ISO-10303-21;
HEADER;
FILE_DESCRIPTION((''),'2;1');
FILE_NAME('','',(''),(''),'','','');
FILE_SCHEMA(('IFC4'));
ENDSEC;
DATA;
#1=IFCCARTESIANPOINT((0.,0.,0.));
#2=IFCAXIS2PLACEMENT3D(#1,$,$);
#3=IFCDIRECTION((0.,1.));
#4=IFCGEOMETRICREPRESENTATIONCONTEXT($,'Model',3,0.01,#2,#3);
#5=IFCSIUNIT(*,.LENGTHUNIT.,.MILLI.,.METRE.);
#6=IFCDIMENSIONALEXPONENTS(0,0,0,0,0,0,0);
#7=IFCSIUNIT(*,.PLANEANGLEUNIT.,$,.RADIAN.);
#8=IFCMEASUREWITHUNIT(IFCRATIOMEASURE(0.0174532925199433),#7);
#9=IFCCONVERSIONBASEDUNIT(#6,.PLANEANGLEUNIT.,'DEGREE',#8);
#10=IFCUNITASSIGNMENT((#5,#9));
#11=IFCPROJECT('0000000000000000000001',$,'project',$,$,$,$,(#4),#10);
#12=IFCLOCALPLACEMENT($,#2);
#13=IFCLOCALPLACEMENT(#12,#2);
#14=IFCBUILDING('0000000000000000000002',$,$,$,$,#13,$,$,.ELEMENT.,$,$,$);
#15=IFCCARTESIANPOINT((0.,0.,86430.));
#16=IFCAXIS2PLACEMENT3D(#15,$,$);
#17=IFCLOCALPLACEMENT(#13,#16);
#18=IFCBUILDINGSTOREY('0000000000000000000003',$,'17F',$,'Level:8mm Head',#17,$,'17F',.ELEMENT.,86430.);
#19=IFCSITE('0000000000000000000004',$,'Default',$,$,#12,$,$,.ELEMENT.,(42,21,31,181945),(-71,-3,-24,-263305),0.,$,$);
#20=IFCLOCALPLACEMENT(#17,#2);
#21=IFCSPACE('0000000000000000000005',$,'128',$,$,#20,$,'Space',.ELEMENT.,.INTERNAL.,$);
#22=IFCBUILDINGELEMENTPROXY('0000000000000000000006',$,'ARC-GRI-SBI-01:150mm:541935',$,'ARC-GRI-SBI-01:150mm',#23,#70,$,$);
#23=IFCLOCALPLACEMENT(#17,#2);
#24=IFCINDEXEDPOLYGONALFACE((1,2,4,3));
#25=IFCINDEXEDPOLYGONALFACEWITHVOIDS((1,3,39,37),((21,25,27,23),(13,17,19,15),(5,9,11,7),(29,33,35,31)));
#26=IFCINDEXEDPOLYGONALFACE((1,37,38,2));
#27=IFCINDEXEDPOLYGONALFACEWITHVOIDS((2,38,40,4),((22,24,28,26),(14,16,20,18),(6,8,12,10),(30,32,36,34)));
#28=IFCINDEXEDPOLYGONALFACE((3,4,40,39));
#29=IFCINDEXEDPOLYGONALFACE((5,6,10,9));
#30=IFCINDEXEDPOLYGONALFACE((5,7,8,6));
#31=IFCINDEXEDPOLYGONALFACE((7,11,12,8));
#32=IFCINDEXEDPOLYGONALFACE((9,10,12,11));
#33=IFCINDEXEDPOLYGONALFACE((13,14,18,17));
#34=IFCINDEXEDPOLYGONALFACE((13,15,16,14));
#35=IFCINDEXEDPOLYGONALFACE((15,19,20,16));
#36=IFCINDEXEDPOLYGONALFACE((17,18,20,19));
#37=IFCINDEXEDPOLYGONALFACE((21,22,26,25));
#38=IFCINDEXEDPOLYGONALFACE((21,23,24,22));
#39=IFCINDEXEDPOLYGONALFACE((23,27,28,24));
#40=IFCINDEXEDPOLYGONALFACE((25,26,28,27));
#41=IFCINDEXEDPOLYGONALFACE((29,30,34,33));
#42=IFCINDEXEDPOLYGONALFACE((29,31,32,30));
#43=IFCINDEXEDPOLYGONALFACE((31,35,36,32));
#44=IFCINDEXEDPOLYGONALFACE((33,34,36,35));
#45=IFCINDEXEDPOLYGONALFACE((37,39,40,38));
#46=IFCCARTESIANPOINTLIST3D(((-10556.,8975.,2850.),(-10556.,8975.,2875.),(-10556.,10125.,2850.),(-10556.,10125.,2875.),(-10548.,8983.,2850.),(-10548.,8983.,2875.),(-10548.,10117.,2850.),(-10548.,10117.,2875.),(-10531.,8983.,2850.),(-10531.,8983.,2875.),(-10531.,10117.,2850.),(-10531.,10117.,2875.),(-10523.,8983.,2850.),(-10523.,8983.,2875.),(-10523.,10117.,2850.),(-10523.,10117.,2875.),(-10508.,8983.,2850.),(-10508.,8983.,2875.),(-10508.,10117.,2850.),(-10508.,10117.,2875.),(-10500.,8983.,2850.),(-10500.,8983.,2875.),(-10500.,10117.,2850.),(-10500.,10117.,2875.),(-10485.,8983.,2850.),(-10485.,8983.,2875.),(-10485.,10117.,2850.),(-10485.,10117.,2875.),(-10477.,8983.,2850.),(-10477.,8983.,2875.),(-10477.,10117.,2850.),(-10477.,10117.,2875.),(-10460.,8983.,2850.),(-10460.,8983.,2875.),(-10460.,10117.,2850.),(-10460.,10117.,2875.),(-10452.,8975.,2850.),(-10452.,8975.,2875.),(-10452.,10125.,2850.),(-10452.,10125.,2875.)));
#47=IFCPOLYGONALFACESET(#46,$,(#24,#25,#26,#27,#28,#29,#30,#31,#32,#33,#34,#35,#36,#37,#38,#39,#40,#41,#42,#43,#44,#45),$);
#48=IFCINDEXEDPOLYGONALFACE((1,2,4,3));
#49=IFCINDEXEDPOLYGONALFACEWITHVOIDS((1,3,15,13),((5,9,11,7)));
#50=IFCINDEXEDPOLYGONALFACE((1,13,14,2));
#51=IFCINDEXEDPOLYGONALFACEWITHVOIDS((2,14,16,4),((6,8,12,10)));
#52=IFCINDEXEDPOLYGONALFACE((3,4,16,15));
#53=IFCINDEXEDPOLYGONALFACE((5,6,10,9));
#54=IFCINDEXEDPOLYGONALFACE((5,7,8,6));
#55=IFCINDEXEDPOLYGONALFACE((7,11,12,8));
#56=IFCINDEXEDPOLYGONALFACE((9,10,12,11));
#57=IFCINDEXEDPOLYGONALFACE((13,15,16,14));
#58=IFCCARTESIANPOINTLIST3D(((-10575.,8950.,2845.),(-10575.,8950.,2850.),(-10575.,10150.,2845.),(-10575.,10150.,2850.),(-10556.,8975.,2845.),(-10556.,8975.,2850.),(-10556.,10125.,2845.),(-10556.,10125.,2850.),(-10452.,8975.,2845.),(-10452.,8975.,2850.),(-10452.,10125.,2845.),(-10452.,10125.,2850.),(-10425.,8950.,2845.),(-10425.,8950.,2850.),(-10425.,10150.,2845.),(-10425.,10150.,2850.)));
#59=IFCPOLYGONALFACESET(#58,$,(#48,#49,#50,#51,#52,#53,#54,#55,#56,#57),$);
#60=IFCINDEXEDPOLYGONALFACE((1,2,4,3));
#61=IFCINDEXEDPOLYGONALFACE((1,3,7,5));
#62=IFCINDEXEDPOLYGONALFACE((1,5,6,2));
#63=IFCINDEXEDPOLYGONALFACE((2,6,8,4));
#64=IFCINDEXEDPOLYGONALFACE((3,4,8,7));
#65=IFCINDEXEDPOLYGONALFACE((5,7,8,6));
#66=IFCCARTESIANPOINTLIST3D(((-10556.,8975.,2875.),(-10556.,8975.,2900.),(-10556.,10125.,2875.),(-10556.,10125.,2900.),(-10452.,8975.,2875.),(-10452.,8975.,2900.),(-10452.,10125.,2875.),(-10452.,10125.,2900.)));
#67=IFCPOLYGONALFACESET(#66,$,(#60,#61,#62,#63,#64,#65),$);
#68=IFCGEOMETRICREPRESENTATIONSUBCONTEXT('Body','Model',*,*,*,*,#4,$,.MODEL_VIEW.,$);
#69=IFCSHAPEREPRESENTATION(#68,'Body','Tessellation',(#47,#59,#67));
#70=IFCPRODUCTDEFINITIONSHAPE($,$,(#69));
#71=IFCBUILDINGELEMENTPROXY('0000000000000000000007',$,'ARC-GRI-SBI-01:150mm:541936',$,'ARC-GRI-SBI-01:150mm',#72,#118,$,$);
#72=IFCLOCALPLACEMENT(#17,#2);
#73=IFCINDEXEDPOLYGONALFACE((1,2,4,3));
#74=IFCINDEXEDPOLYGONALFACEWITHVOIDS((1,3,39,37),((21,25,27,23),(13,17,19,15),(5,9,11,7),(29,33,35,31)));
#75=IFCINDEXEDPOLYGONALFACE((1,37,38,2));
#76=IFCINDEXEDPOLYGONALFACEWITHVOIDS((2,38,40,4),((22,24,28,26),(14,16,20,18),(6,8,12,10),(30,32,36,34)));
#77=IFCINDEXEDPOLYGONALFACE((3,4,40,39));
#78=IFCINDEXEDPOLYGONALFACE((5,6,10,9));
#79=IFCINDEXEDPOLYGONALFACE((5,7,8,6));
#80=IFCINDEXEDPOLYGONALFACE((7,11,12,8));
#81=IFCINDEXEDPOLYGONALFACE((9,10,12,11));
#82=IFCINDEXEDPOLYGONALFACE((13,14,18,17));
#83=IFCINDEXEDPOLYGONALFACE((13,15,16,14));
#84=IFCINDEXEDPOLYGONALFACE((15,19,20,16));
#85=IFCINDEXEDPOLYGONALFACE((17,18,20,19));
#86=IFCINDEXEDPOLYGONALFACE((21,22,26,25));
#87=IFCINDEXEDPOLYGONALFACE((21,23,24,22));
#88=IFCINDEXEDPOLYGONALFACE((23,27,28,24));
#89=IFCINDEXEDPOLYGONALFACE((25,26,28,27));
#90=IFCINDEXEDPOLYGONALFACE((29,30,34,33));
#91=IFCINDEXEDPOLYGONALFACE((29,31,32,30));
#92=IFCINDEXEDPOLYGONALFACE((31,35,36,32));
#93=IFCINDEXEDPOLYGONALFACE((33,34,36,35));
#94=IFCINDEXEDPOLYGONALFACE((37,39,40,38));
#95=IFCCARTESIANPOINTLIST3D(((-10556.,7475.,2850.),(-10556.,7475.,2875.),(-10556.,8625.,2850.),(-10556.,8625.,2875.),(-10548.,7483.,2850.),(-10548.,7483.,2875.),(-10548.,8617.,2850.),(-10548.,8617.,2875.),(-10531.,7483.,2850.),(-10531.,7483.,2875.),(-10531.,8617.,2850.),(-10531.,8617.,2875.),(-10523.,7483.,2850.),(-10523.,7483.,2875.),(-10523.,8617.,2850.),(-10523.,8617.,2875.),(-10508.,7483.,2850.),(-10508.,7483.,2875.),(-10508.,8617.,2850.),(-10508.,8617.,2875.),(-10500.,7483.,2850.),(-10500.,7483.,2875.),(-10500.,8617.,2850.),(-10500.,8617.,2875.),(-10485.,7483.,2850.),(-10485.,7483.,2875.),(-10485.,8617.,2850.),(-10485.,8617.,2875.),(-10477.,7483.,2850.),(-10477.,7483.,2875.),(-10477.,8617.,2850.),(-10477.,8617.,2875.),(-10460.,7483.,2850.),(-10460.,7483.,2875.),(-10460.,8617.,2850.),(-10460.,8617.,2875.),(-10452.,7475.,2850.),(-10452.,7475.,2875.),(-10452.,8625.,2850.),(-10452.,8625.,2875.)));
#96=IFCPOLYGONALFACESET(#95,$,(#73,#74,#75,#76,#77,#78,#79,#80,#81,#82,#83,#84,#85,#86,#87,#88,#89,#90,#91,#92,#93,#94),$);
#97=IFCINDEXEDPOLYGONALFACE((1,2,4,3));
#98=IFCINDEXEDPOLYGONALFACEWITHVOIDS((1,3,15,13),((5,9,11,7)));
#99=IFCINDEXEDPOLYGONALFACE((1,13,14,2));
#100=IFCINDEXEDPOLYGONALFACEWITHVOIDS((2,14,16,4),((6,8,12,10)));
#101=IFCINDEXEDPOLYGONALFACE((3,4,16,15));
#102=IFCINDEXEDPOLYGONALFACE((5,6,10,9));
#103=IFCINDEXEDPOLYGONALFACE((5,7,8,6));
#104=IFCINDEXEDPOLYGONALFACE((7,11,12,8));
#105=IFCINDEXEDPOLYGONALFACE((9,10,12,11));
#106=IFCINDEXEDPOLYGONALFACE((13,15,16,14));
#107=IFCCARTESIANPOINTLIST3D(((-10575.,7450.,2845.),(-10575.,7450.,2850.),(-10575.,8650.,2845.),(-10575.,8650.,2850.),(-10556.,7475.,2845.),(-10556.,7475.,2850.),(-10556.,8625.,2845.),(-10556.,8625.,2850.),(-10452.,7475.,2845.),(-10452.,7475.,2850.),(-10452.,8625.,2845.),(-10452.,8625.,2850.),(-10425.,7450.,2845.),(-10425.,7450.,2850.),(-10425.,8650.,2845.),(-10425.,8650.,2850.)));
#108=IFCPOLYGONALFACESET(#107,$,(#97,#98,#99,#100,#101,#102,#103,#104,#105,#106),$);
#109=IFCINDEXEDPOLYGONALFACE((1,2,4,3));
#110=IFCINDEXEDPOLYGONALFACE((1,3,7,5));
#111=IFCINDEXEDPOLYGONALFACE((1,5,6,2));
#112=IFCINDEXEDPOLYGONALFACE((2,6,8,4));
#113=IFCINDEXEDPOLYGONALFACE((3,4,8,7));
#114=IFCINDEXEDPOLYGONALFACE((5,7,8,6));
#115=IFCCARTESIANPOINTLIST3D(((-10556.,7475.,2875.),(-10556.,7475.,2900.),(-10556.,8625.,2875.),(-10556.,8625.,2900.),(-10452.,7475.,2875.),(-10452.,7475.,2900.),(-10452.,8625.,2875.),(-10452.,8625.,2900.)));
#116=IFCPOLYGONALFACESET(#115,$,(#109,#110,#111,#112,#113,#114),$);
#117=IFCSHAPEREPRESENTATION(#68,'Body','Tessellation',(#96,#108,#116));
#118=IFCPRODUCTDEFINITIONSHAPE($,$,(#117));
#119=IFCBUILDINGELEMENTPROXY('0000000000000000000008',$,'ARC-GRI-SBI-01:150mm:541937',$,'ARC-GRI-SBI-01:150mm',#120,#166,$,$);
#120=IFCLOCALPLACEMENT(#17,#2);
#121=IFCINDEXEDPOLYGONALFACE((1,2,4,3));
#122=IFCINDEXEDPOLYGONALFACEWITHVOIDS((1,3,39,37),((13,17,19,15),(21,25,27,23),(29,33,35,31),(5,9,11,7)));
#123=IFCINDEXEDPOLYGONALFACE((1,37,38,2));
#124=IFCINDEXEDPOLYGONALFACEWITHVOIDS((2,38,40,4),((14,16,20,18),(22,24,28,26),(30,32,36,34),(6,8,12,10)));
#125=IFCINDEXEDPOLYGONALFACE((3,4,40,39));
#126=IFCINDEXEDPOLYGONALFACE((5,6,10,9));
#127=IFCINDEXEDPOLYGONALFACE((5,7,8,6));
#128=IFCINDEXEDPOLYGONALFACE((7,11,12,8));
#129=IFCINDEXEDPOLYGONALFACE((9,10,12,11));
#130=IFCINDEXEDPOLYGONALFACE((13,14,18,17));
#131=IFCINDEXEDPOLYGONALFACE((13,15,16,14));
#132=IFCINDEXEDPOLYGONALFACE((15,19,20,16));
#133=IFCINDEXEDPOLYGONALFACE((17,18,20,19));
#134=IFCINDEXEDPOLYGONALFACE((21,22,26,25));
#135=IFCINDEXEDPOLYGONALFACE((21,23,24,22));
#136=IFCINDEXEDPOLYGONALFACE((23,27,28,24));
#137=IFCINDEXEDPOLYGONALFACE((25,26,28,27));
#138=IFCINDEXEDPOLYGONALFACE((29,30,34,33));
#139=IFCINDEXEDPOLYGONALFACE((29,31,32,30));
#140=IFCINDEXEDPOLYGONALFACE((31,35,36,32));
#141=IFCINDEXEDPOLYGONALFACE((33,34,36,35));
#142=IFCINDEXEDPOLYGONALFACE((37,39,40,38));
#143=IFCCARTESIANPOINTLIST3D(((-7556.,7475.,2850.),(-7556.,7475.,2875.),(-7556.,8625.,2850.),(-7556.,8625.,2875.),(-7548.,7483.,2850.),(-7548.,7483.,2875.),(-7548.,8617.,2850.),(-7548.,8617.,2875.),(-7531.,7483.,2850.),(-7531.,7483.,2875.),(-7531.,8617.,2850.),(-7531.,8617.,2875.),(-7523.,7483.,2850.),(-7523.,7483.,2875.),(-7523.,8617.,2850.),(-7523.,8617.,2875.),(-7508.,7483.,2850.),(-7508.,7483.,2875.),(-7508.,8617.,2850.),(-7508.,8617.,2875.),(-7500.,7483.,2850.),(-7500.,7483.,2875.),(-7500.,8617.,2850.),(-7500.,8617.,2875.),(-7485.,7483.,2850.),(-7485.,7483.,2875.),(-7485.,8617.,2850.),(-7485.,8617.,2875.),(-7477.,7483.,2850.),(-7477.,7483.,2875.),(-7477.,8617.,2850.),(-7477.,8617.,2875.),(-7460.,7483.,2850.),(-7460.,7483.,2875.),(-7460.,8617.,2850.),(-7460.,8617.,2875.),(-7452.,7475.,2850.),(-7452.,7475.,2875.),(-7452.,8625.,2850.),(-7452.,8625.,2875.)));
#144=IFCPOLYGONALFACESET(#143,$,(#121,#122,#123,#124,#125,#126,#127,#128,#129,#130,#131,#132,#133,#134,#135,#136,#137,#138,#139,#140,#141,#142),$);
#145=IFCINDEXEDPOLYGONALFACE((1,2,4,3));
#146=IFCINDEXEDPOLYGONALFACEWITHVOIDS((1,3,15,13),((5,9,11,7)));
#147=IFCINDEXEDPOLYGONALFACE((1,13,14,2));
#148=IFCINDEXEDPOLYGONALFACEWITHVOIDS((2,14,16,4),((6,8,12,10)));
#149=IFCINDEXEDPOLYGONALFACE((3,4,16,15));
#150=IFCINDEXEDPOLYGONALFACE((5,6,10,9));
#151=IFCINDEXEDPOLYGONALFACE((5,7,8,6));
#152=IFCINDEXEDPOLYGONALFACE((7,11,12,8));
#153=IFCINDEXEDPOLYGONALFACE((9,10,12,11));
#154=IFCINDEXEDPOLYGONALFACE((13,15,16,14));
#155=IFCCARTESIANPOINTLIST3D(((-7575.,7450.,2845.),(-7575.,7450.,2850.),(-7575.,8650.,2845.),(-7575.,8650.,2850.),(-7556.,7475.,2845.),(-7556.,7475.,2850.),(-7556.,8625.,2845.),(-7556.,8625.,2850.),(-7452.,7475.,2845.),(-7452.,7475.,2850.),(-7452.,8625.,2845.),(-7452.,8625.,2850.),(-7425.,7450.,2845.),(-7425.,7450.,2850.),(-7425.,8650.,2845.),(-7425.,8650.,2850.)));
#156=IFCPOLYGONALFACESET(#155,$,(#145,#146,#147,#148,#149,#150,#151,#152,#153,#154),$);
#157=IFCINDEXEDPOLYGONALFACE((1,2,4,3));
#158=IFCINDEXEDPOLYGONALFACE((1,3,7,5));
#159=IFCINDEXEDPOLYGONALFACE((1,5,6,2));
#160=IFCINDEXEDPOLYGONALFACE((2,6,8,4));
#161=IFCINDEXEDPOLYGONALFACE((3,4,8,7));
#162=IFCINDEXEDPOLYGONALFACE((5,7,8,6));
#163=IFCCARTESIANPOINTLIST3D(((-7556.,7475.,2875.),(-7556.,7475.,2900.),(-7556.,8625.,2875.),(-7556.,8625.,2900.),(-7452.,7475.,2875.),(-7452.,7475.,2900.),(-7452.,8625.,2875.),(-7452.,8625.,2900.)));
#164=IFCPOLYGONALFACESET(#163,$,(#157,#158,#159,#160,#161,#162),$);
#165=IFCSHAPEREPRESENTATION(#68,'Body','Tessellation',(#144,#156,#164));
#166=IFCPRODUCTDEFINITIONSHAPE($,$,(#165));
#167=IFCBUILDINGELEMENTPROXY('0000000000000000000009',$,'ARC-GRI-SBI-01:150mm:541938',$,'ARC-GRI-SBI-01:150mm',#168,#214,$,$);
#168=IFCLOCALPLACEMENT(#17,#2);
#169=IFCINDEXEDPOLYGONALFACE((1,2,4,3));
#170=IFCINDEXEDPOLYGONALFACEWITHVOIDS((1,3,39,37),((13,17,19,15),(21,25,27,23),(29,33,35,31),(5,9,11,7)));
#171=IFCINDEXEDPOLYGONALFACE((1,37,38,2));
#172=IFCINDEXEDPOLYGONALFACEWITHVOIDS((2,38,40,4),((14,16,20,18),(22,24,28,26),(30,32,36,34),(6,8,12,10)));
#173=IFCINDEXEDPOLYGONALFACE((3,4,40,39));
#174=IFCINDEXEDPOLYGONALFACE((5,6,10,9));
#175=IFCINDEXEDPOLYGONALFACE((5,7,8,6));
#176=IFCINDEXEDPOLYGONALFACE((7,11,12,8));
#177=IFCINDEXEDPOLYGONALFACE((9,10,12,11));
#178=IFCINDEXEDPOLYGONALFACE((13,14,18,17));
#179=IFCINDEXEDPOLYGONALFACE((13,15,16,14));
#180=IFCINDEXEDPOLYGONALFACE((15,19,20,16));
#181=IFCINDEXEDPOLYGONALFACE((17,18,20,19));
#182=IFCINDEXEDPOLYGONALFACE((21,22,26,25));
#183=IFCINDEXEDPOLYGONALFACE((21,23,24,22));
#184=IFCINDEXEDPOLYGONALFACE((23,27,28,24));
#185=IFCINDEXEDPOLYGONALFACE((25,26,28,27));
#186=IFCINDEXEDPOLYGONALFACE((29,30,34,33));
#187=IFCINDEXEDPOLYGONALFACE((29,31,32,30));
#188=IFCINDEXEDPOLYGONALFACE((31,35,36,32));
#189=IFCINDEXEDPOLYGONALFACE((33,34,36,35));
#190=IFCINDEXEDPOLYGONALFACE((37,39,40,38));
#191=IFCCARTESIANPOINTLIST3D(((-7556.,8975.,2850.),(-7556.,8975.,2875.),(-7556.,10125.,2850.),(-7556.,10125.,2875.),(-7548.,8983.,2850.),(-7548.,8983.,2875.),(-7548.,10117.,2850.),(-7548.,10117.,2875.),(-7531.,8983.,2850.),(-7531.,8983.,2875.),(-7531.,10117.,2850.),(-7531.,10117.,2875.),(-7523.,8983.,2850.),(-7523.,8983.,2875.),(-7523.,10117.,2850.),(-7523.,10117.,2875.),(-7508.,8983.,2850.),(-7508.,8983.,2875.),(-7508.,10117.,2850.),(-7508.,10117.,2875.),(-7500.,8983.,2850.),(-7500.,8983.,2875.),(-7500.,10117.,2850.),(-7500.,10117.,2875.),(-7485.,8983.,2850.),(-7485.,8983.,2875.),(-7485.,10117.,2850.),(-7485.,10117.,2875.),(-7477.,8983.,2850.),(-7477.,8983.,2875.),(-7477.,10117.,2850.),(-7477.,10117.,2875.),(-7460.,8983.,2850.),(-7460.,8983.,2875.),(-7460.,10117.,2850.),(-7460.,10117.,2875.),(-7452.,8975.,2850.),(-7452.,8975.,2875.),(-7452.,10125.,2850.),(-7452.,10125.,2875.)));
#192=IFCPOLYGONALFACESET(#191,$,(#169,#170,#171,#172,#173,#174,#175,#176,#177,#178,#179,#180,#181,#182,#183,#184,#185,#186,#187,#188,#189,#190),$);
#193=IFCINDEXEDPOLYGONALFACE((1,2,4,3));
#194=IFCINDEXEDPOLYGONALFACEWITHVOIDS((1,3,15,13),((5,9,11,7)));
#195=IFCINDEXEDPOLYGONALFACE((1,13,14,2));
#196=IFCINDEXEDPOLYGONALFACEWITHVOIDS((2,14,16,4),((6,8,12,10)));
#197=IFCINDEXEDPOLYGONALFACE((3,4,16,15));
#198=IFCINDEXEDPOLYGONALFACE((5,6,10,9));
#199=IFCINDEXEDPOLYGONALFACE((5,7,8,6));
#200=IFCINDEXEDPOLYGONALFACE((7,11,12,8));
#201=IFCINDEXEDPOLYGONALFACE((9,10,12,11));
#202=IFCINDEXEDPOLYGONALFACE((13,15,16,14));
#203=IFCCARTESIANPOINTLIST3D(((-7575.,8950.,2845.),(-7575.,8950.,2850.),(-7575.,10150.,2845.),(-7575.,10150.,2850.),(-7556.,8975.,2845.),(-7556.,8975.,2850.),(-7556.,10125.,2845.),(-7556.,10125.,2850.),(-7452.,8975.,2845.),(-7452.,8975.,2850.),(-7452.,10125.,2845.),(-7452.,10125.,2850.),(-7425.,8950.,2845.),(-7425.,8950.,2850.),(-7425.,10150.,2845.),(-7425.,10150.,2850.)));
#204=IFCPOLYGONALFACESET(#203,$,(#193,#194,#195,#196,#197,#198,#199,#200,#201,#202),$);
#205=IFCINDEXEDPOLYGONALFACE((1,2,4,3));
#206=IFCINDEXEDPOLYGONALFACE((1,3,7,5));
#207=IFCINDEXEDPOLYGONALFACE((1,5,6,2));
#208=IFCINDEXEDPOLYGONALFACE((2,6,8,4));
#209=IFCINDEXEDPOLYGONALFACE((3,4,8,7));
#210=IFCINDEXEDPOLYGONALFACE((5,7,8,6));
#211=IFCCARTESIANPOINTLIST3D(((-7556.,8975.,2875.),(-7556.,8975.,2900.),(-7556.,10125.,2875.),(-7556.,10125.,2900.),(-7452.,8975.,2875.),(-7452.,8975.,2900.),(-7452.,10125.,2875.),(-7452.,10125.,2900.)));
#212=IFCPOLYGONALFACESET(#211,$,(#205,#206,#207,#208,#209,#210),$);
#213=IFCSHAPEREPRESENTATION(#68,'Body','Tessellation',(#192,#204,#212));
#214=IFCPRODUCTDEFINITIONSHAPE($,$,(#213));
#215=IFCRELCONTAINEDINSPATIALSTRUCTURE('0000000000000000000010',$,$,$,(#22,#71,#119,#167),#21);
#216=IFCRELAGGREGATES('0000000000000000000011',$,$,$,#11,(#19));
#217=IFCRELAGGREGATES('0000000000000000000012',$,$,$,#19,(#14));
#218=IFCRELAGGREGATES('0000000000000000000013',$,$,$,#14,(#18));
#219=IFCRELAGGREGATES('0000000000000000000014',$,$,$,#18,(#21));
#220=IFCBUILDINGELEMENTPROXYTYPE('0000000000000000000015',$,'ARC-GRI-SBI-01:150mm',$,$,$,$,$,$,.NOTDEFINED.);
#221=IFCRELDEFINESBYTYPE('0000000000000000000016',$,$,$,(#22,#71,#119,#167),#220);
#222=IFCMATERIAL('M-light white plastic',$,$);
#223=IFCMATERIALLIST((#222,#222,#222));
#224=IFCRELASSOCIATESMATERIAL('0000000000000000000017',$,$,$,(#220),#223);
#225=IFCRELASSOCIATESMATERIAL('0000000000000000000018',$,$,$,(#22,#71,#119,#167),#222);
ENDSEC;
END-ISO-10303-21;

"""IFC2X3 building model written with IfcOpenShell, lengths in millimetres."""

from ifc_helpers import new_model, entity, si_unit, converted_unit, direction, frame, origin, origin_2d_with_axis, place, context, subcontext, project, spatial, polyline, rectangle, outline, extrude, source, transform, mapped, material, material_list, type_object, type_shapes, element, save


model = new_model("IFC2X3")

# Units and contexts
model_context = context("Model", 3, precision=0.01, world=origin(), true_north=direction((0.0, 1.0)))
body_context = subcontext(model_context, "Body", "Model", "MODEL_VIEW")
ifc_project = project(units=[si_unit("LENGTHUNIT", "METRE", prefix="MILLI"), converted_unit("PLANEANGLEUNIT", "DEGREE", entity("IfcRatioMeasure", 0.0174532925199433), si_unit("PLANEANGLEUNIT", "RADIAN"), dimensions=[0, 0, 0, 0, 0, 0, 0])], contexts=[model_context])

# Site, building, storey, space
site_placement = place(None, origin())
site = spatial("IfcSite", under=ifc_project, at=site_placement, Name="Default", CompositionType="ELEMENT", RefLatitude=(42, 21, 31, 181945), RefLongitude=(-71, -3, -24, -263305), RefElevation=0.0)
building_placement = place(site_placement, origin())
building = spatial("IfcBuilding", under=site, at=building_placement, CompositionType="ELEMENT")
storey_placement = place(building_placement, frame((0.0, 0.0, 86430.0)))
storey = spatial("IfcBuildingStorey", under=building, at=storey_placement, Name="17F", ObjectType="Level:8mm Head", LongName="17F", CompositionType="ELEMENT", Elevation=86430.0)
space_placement = place(storey_placement, origin())
space = spatial("IfcSpace", under=storey, at=space_placement, Name="128", LongName="Space", CompositionType="ELEMENT", InteriorOrExteriorSpace="INTERNAL")

# Shared definitions
ifc_material_1 = material(Name="M-light white plastic")

# Building element proxies
ifc_material_list_1 = material_list([ifc_material_1, ifc_material_1, ifc_material_1])
building_element_proxy_type = type_object("IfcBuildingElementProxyType", Name="ARC-GRI-SBI-01:150mm", PredefinedType="NOTDEFINED", material=ifc_material_list_1)
shared_shape_1 = source(origin(), body_context, "Body", "SweptSolid", [
    extrude(outline(polyline([(-575.0, -52.0), (575.0, -52.0), (575.0, 52.0), (-575.0, 52.0), (-575.0, -52.0)]), holes=[polyline([(-567.0, -44.0), (-567.0, -27.0), (567.0, -27.0), (567.0, -44.0), (-567.0, -44.0)]), polyline([(567.0, -4.0), (567.0, -19.0), (-567.0, -19.0), (-567.0, -4.0), (567.0, -4.0)]), polyline([(-567.0, 44.0), (567.0, 44.0), (567.0, 27.0), (-567.0, 27.0), (-567.0, 44.0)]), polyline([(567.0, 4.0), (-567.0, 4.0), (-567.0, 19.0), (567.0, 19.0), (567.0, 4.0)])]), frame((425.0, 4.0, 4000.0), z_axis=(0.0, 0.0, 1.0), x_axis=(-1.0, 0.0, 0.0)), (0.0, 0.0, 1.0), 25.0),
    extrude(outline(polyline([(-600.0, -75.0), (600.0, -75.0), (600.0, 75.0), (-600.0, 75.0), (-600.0, -75.0)]), holes=[polyline([(-575.0, -56.0), (-575.0, 48.0), (575.0, 48.0), (575.0, -56.0), (-575.0, -56.0)])]), frame((425.0, 0.0, 3995.0), z_axis=(0.0, 0.0, 1.0), x_axis=(-1.0, 0.0, 0.0)), (0.0, 0.0, 1.0), 5.0),
    extrude(rectangle(XDim=1150.0, YDim=104.0, at=origin_2d_with_axis()), frame((425.0, 4.0, 4025.0), z_axis=(0.0, 0.0, 1.0), x_axis=(-1.0, 0.0, 0.0)), (0.0, 0.0, 1.0), 25.0),
])
type_shapes(building_element_proxy_type, [shared_shape_1])
for number, where, z_axis, x_axis, name in (
    (1, (-10500.0, 9125.0, -1150.0), (0.0, 0.0, 1.0), (0.0, 1.0, 0.0), "ARC-GRI-SBI-01:150mm:541935"),
    (2, (-10500.0, 7625.0, -1150.0), (0.0, 0.0, 1.0), (0.0, 1.0, 0.0), "ARC-GRI-SBI-01:150mm:541936"),
    (3, (-7500.0, 7625.0, -1150.0), (0.0, 0.0, 1.0), (0.0, 1.0, 0.0), "ARC-GRI-SBI-01:150mm:541937"),
    (4, (-7500.0, 9125.0, -1150.0), (0.0, 0.0, 1.0), (0.0, 1.0, 0.0), "ARC-GRI-SBI-01:150mm:541938"),
):
    element("IfcBuildingElementProxy", number, at=place(space_placement, frame(where, z_axis=z_axis, x_axis=x_axis)), inside=space, type_object=building_element_proxy_type, material=ifc_material_1, Name=name, ObjectType="ARC-GRI-SBI-01:150mm", context=body_context, shape_type="MappedRepresentation", body=[
        mapped(shared_shape_1, transform((0.0, 0.0, 0.0), scale=1.0)),
    ])

save(model, "model.ifc")
